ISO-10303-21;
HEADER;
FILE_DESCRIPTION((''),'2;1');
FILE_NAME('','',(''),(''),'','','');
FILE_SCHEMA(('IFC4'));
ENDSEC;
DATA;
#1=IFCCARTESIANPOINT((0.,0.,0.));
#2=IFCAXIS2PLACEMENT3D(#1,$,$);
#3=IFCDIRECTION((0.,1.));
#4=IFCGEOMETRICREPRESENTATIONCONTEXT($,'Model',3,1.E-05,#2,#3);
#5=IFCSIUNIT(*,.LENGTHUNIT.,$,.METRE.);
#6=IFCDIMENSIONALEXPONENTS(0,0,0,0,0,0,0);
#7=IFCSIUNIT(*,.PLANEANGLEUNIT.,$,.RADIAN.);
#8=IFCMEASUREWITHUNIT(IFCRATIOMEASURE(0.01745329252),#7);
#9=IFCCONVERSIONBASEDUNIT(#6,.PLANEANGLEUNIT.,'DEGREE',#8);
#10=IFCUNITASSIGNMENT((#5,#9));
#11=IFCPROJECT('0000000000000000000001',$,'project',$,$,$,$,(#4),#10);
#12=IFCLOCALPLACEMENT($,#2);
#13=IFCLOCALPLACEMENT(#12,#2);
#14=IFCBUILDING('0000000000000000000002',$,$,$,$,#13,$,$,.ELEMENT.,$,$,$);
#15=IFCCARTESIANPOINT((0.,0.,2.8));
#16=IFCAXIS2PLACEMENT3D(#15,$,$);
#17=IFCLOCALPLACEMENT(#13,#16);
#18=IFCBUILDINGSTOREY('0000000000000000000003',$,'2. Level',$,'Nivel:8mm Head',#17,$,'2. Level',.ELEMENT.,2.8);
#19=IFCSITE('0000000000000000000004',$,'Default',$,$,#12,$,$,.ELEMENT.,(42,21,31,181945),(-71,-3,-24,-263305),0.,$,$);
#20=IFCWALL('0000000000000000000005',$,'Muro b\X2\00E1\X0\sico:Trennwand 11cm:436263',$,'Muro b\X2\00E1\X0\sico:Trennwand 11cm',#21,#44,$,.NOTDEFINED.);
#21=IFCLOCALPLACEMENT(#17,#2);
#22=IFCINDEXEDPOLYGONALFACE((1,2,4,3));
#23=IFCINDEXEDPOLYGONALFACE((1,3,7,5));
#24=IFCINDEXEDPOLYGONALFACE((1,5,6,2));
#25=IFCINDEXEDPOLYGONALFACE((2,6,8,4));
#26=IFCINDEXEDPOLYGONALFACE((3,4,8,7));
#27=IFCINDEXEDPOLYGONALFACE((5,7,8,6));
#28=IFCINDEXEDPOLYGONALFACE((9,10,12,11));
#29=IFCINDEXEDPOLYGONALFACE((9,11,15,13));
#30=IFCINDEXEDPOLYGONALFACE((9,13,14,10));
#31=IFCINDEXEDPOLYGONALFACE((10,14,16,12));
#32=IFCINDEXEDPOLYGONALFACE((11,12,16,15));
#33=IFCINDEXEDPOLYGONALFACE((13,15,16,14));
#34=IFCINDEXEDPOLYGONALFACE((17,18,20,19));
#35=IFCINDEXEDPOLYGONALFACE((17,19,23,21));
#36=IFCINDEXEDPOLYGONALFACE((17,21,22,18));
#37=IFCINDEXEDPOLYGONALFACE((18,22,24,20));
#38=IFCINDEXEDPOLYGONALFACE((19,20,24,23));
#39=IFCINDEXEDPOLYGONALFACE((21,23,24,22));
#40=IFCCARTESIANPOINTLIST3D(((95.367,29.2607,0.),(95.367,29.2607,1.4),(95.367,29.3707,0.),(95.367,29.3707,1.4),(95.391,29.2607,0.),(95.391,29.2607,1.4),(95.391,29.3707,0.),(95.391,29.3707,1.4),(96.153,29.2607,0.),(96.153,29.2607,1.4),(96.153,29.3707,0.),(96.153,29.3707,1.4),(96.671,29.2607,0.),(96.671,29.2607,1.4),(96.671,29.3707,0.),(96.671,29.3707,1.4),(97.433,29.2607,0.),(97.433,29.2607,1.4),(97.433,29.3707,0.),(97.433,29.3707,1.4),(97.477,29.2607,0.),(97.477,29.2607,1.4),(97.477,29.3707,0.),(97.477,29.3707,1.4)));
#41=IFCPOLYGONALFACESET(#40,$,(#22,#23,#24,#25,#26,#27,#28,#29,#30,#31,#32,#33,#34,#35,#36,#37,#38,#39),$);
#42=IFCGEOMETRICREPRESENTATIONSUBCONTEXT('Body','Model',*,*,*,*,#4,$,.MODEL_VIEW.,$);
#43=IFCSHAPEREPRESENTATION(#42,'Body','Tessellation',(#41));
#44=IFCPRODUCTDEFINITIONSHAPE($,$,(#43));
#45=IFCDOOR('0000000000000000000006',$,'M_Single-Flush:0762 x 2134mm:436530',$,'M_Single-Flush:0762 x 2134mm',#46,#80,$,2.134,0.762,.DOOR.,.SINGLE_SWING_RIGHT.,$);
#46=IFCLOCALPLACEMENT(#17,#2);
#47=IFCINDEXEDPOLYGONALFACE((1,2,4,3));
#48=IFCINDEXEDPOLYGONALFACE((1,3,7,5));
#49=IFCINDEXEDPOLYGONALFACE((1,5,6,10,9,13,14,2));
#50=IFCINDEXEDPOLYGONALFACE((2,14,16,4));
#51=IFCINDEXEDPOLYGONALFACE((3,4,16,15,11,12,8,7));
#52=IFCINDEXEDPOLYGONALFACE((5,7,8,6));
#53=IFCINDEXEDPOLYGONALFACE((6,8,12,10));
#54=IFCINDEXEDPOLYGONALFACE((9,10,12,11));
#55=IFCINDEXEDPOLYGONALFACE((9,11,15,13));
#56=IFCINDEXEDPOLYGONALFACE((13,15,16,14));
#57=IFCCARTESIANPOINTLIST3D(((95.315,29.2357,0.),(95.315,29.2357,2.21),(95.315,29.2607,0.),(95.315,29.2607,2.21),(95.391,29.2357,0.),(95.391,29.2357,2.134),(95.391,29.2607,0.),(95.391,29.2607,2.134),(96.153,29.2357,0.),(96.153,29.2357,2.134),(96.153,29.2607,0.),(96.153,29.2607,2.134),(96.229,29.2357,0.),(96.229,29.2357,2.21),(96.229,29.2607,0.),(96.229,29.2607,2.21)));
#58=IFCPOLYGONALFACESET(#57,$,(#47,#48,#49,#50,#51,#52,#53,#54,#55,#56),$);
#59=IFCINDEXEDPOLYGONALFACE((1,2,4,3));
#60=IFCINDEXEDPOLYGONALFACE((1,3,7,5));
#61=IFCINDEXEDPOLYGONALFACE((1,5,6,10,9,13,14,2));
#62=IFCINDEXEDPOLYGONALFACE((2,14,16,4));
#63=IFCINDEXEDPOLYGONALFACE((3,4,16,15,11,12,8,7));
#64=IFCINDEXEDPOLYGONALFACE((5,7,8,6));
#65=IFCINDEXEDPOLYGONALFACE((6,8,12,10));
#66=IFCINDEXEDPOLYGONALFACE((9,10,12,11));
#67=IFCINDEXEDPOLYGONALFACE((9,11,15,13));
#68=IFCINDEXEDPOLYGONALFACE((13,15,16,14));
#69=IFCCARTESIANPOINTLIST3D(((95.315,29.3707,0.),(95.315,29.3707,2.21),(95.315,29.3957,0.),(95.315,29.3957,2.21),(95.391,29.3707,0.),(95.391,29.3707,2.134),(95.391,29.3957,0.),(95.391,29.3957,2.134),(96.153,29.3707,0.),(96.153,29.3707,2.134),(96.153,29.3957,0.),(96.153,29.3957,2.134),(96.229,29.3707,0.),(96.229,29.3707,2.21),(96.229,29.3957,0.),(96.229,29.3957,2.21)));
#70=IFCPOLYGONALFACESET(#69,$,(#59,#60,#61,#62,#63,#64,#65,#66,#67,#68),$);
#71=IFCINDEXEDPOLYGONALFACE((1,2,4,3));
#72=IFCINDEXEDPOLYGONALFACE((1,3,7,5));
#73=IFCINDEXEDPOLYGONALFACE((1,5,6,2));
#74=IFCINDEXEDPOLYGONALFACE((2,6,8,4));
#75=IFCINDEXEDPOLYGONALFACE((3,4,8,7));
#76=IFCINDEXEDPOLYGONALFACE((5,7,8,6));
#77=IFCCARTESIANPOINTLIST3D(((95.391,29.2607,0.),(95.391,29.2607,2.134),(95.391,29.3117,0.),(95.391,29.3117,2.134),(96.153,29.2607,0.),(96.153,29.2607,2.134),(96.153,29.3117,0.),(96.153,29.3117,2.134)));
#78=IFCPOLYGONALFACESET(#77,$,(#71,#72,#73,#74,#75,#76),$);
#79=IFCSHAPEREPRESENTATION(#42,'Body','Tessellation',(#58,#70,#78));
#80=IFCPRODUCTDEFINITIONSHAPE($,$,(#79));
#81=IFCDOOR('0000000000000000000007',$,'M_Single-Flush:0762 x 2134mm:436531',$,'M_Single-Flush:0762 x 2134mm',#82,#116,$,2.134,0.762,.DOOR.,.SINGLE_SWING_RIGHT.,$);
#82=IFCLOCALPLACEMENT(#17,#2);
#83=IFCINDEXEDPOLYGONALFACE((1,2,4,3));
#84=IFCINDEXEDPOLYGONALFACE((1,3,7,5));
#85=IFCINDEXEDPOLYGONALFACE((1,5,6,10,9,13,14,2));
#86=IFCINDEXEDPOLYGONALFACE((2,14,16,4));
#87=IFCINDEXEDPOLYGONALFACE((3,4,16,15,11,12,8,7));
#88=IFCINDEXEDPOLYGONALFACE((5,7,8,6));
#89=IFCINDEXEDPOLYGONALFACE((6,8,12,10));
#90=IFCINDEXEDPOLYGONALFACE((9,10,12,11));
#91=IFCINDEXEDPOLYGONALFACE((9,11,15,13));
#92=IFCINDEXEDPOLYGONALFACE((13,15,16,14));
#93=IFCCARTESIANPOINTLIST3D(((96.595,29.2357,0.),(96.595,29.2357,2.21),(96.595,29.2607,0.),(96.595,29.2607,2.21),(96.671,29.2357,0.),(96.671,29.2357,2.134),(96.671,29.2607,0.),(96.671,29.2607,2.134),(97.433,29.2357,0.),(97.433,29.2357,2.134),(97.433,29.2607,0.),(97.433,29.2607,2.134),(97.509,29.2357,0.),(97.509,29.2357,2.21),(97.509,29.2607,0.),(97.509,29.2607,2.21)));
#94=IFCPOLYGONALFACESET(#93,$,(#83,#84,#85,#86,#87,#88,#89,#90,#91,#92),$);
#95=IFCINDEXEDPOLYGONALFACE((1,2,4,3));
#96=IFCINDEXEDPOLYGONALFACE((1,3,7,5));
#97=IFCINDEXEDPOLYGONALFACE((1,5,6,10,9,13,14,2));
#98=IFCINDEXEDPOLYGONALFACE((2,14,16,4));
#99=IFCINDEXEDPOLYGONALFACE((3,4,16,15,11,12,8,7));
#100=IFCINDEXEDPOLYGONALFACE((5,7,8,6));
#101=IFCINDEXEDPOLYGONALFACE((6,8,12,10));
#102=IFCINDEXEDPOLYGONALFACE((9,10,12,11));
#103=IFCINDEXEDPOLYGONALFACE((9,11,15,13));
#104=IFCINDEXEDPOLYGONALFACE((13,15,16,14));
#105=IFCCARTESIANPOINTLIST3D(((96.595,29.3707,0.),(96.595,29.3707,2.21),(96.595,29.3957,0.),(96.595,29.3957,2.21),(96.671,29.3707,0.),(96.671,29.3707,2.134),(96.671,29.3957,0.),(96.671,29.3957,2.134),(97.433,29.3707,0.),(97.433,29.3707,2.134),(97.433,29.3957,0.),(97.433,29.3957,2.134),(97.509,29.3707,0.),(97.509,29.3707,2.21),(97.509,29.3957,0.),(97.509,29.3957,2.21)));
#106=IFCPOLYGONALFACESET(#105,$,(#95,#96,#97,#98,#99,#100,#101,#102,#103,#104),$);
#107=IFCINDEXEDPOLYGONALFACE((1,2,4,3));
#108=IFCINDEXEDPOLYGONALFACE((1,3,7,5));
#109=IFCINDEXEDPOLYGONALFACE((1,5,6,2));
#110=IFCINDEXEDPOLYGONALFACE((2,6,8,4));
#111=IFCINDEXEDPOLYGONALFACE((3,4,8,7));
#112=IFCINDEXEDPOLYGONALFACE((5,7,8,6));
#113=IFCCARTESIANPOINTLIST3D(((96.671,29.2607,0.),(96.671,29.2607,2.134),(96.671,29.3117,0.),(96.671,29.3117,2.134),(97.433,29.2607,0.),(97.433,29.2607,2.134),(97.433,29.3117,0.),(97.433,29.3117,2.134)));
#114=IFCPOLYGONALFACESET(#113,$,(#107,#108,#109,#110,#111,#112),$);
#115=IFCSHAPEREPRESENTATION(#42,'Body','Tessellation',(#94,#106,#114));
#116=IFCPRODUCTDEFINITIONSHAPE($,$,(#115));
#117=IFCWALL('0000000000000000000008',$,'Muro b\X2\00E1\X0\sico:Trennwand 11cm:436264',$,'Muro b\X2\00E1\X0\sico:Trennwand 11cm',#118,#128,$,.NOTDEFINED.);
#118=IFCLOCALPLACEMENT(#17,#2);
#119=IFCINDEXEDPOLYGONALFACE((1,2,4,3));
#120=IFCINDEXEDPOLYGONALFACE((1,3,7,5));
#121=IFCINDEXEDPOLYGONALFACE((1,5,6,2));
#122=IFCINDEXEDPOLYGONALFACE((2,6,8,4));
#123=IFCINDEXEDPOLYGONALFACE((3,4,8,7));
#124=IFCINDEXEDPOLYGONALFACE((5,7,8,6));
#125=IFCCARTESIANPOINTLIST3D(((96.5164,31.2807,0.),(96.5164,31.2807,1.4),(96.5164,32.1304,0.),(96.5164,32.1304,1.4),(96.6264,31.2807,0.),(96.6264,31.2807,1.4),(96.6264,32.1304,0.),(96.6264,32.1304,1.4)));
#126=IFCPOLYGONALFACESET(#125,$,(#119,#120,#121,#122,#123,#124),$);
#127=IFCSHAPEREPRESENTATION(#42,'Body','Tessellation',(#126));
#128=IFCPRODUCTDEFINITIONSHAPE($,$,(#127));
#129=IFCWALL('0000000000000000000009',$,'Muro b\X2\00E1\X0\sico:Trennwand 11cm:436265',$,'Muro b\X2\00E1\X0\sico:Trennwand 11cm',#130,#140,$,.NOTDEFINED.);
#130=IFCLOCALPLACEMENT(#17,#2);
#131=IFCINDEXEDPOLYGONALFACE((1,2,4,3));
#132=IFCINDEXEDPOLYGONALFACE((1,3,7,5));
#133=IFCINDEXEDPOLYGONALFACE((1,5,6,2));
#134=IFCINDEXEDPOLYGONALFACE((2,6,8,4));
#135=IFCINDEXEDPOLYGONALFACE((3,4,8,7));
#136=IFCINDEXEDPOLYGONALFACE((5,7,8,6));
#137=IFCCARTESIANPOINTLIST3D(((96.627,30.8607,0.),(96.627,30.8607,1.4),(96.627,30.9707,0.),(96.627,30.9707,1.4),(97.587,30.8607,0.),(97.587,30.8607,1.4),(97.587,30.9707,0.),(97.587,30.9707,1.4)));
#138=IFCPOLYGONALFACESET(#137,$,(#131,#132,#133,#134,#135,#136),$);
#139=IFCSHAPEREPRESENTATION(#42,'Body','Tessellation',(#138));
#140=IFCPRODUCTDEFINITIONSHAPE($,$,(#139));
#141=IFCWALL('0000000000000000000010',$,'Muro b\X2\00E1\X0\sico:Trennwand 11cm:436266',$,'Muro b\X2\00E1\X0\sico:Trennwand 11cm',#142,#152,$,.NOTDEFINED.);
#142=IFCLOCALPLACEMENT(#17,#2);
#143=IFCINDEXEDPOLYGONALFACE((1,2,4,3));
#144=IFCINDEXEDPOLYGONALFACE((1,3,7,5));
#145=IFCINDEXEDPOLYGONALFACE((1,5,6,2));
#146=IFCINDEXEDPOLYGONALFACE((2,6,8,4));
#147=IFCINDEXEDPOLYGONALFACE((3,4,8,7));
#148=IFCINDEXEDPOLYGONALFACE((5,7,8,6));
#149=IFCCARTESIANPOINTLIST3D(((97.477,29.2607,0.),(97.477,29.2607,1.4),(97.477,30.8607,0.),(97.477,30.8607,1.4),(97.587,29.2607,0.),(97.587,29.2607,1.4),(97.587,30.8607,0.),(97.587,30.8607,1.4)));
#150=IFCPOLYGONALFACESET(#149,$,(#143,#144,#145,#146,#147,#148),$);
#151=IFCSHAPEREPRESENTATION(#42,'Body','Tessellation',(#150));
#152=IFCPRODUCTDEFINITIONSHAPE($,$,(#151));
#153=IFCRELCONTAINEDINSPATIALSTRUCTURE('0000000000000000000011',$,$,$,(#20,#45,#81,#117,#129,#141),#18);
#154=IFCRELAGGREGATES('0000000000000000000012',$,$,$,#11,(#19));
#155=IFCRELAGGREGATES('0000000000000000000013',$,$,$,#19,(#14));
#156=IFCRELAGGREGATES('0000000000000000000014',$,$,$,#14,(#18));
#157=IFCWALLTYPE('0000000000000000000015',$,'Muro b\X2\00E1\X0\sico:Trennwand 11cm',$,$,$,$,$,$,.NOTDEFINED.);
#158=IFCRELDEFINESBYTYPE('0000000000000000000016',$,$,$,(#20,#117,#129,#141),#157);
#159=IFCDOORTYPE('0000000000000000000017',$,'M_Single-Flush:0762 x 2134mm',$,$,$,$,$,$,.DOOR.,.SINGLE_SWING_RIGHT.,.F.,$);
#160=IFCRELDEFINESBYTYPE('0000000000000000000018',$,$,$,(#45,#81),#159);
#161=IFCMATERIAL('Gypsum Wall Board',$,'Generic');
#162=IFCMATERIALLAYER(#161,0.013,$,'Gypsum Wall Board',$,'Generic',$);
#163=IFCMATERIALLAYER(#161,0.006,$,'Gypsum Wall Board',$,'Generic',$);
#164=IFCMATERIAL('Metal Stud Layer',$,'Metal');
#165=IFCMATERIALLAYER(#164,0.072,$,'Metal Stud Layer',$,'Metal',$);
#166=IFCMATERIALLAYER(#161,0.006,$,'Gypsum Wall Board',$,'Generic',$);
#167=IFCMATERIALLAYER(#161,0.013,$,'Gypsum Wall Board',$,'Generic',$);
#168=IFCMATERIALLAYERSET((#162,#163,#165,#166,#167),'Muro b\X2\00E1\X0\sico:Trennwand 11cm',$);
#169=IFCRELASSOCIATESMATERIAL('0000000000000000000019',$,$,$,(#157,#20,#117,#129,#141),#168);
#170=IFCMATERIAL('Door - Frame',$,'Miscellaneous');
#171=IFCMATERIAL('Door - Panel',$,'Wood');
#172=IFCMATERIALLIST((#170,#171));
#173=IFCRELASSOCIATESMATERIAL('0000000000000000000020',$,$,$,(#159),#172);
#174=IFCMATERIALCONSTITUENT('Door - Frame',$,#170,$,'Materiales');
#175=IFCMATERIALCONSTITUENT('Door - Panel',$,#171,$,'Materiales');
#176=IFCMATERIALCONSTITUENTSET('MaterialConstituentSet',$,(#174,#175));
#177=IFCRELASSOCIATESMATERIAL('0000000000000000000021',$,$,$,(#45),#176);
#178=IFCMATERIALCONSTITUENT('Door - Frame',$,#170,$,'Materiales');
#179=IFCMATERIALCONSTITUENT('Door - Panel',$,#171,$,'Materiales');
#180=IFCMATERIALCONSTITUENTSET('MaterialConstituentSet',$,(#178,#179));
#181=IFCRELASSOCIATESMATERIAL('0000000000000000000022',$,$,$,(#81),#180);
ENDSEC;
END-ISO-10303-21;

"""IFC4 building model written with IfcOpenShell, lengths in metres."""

from ifc_helpers import new_model, entity, si_unit, converted_unit, direction, frame, frame_2d, origin, origin_2d_with_axis, place, context, subcontext, project, spatial, polyline, rectangle, outline, extrude, clip, halfspace, source, transform, mapped, material, material_list, layer, layer_set, layer_usage, constituent, constituent_set, type_object, type_shapes, element, fill, save


model = new_model("IFC4")

# Units and contexts
model_context = context("Model", 3, precision=1e-05, world=origin(), true_north=direction((0.0, 1.0)))
body_context = subcontext(model_context, "Body", "Model", "MODEL_VIEW")
ifc_project = project(units=[si_unit("LENGTHUNIT", "METRE"), converted_unit("PLANEANGLEUNIT", "DEGREE", entity("IfcRatioMeasure", 0.01745329252), si_unit("PLANEANGLEUNIT", "RADIAN"), dimensions=[0, 0, 0, 0, 0, 0, 0])], contexts=[model_context])

# Site, building, storey
site_placement = place(None, origin())
site = spatial("IfcSite", under=ifc_project, at=site_placement, Name="Default", CompositionType="ELEMENT", RefLatitude=(42, 21, 31, 181945), RefLongitude=(-71, -3, -24, -263305), RefElevation=0.0)
building_placement = place(site_placement, origin())
building = spatial("IfcBuilding", under=site, at=building_placement, CompositionType="ELEMENT")
storey_placement = place(building_placement, frame((0.0, 0.0, 2.8)))
storey = spatial("IfcBuildingStorey", under=building, at=storey_placement, Name="2. Level", ObjectType="Nivel:8mm Head", LongName="2. Level", CompositionType="ELEMENT", Elevation=2.8)

# Shared definitions
ifc_material_1 = material(Name="Gypsum Wall Board", Category="Generic")
ifc_layer_1 = layer(ifc_material_1, 0.013, Name="Gypsum Wall Board", Category="Generic")
ifc_layer_2 = layer(ifc_material_1, 0.006, Name="Gypsum Wall Board", Category="Generic")
ifc_material_2 = material(Name="Metal Stud Layer", Category="Metal")
ifc_layer_3 = layer(ifc_material_2, 0.072, Name="Metal Stud Layer", Category="Metal")
ifc_layer_4 = layer(ifc_material_1, 0.006, Name="Gypsum Wall Board", Category="Generic")
ifc_layer_5 = layer(ifc_material_1, 0.013, Name="Gypsum Wall Board", Category="Generic")
ifc_layer_set_1 = layer_set([ifc_layer_1, ifc_layer_2, ifc_layer_3, ifc_layer_4, ifc_layer_5], Name="Muro básico:Trennwand 11cm")
wall_type_1 = type_object("IfcWallType", Name="Muro básico:Trennwand 11cm", PredefinedType="NOTDEFINED", material=ifc_layer_set_1)

# Wall, openings, doors
ifc_layer_usage_1 = layer_usage(ifc_layer_set_1, "AXIS2", "NEGATIVE", 0.055)
wall_1_placement = place(storey_placement, frame((97.477, 29.3157, 0.0), z_axis=(0.0, 0.0, 1.0), x_axis=(-1.0, 0.0, 0.0)))
wall_1 = element("IfcWall", 1, at=wall_1_placement, inside=storey, type_object=wall_type_1, material=ifc_layer_usage_1, Name="Muro básico:Trennwand 11cm:436263", ObjectType="Muro básico:Trennwand 11cm", PredefinedType="NOTDEFINED", context=body_context, shape_type="Clipping", body=[
    clip(extrude(rectangle(XDim=2.11, YDim=0.11, at=frame_2d((1.055, 0.0), x_axis=(-1.0, 0.0))), origin(), (0.0, 0.0, 1.0), 1.4), halfspace(origin(), True)),
])
opening_1_placement = place(wall_1_placement, frame((1.324, -0.055, 0.0)))
opening_1 = element("IfcOpeningElement", 2, at=opening_1_placement, cuts=wall_1, ObjectType="Opening", PredefinedType="OPENING", context=body_context, shape_type="SweptSolid", body=[
    extrude(rectangle(XDim=0.762, YDim=2.134, at=frame_2d((1.067, 0.381), x_axis=(0.0, 1.0))), frame((0.0, 0.0, 0.0), z_axis=(0.0, 1.0, 0.0), x_axis=(0.0, 0.0, 1.0)), (0.0, 0.0, 1.0), 0.11),
])
opening_2_placement = place(wall_1_placement, frame((0.044, -0.055, 0.0)))
opening_2 = element("IfcOpeningElement", 3, at=opening_2_placement, cuts=wall_1, ObjectType="Opening", PredefinedType="OPENING", context=body_context, shape_type="SweptSolid", body=[
    extrude(rectangle(XDim=0.762, YDim=2.134, at=frame_2d((1.067, 0.381), x_axis=(0.0, 1.0))), frame((0.0, 0.0, 0.0), z_axis=(0.0, 1.0, 0.0), x_axis=(0.0, 0.0, 1.0)), (0.0, 0.0, 1.0), 0.11),
])
ifc_material_3 = material(Name="Door - Frame", Category="Miscellaneous")
ifc_constituent_1 = constituent(ifc_material_3, Name="Door - Frame", Category="Materiales")
ifc_material_4 = material(Name="Door - Panel", Category="Wood")
ifc_constituent_2 = constituent(ifc_material_4, Name="Door - Panel", Category="Materiales")
ifc_constituent_set_1 = constituent_set(constituents=[ifc_constituent_1, ifc_constituent_2], Name="MaterialConstituentSet")
ifc_material_list_1 = material_list([ifc_material_3, ifc_material_4])
door_type = type_object("IfcDoorType", Name="M_Single-Flush:0762 x 2134mm", OperationType="SINGLE_SWING_RIGHT", ParameterTakesPrecedence=False, PredefinedType="DOOR", material=ifc_material_list_1)
shared_shape_1 = source(origin(), body_context, "Body", "SweptSolid", [
    extrude(outline(polyline([(-0.457, -1.124), (0.457, -1.124), (0.457, 1.086), (0.381, 1.086), (0.381, -1.048), (-0.381, -1.048), (-0.381, 1.086), (-0.457, 1.086), (-0.457, -1.124)])), frame((0.381, 0.11, 1.086), z_axis=(0.0, 1.0, 0.0), x_axis=(1.0, 0.0, 0.0)), (0.0, 0.0, 1.0), 0.025),
    extrude(outline(polyline([(-1.124, -0.457), (1.086, -0.457), (1.086, -0.381), (-1.048, -0.381), (-1.048, 0.381), (1.086, 0.381), (1.086, 0.457), (-1.124, 0.457), (-1.124, -0.457)])), frame((0.381, -0.025, 1.086), z_axis=(0.0, 1.0, 0.0), x_axis=(0.0, 0.0, -1.0)), (0.0, 0.0, 1.0), 0.025),
    extrude(rectangle(XDim=0.051, YDim=0.762, at=origin_2d_with_axis()), frame((0.381, 0.0845, 0.0), z_axis=(0.0, 0.0, 1.0), x_axis=(0.0, 1.0, 0.0)), (0.0, 0.0, 1.0), 2.134),
])
type_shapes(door_type, [shared_shape_1])
door_1_placement = place(opening_1_placement, origin())
door_1 = element("IfcDoor", 4, at=door_1_placement, inside=storey, type_object=door_type, material=ifc_constituent_set_1, Name="M_Single-Flush:0762 x 2134mm:436530", ObjectType="M_Single-Flush:0762 x 2134mm", OperationType="SINGLE_SWING_RIGHT", OverallHeight=2.134, OverallWidth=0.762, PredefinedType="DOOR", context=body_context, shape_type="MappedRepresentation", body=[
    mapped(shared_shape_1, transform((0.0, 0.0, 0.0), scale=1.0)),
])
fill(opening_1, door_1)
ifc_constituent_3 = constituent(ifc_material_3, Name="Door - Frame", Category="Materiales")
ifc_constituent_4 = constituent(ifc_material_4, Name="Door - Panel", Category="Materiales")
ifc_constituent_set_2 = constituent_set(constituents=[ifc_constituent_3, ifc_constituent_4], Name="MaterialConstituentSet")
door_2_placement = place(opening_2_placement, origin())
door_2 = element("IfcDoor", 5, at=door_2_placement, inside=storey, type_object=door_type, material=ifc_constituent_set_2, Name="M_Single-Flush:0762 x 2134mm:436531", ObjectType="M_Single-Flush:0762 x 2134mm", OperationType="SINGLE_SWING_RIGHT", OverallHeight=2.134, OverallWidth=0.762, PredefinedType="DOOR", context=body_context, shape_type="MappedRepresentation", body=[
    mapped(shared_shape_1, transform((0.0, 0.0, 0.0), scale=1.0)),
])
fill(opening_2, door_2)

# Walls
ifc_layer_usage_2 = layer_usage(ifc_layer_set_1, "AXIS2", "NEGATIVE", 0.055)
wall_2_placement = place(storey_placement, frame((96.5714, 32.1304, 0.0), z_axis=(0.0, 0.0, 1.0), x_axis=(0.0, -1.0, 0.0)))
element("IfcWall", 6, at=wall_2_placement, inside=storey, type_object=wall_type_1, material=ifc_layer_usage_2, Name="Muro básico:Trennwand 11cm:436264", ObjectType="Muro básico:Trennwand 11cm", PredefinedType="NOTDEFINED", context=body_context, shape_type="Clipping", body=[
    clip(extrude(rectangle(XDim=0.8497, YDim=0.11, at=frame_2d((0.4248, 0.0), x_axis=(-1.0, 0.0))), origin(), (0.0, 0.0, 1.0), 1.4), halfspace(origin(), True)),
])
ifc_layer_usage_3 = layer_usage(ifc_layer_set_1, "AXIS2", "NEGATIVE", 0.055)
wall_3_placement = place(storey_placement, frame((96.627, 30.9157, 0.0)))
element("IfcWall", 7, at=wall_3_placement, inside=storey, type_object=wall_type_1, material=ifc_layer_usage_3, Name="Muro básico:Trennwand 11cm:436265", ObjectType="Muro básico:Trennwand 11cm", PredefinedType="NOTDEFINED", context=body_context, shape_type="Clipping", body=[
    clip(extrude(rectangle(XDim=0.96, YDim=0.11, at=frame_2d((0.48, 0.0), x_axis=(-1.0, 0.0))), origin(), (0.0, 0.0, 1.0), 1.4), halfspace(origin(), True)),
])
ifc_layer_usage_4 = layer_usage(ifc_layer_set_1, "AXIS2", "NEGATIVE", 0.055)
wall_4_placement = place(storey_placement, frame((97.532, 30.8607, 0.0), z_axis=(0.0, 0.0, 1.0), x_axis=(0.0, -1.0, 0.0)))
element("IfcWall", 8, at=wall_4_placement, inside=storey, type_object=wall_type_1, material=ifc_layer_usage_4, Name="Muro básico:Trennwand 11cm:436266", ObjectType="Muro básico:Trennwand 11cm", PredefinedType="NOTDEFINED", context=body_context, shape_type="Clipping", body=[
    clip(extrude(rectangle(XDim=1.6, YDim=0.11, at=frame_2d((0.8, 0.0), x_axis=(-1.0, 0.0))), origin(), (0.0, 0.0, 1.0), 1.4), halfspace(origin(), True)),
])

save(model, "model.ifc")
